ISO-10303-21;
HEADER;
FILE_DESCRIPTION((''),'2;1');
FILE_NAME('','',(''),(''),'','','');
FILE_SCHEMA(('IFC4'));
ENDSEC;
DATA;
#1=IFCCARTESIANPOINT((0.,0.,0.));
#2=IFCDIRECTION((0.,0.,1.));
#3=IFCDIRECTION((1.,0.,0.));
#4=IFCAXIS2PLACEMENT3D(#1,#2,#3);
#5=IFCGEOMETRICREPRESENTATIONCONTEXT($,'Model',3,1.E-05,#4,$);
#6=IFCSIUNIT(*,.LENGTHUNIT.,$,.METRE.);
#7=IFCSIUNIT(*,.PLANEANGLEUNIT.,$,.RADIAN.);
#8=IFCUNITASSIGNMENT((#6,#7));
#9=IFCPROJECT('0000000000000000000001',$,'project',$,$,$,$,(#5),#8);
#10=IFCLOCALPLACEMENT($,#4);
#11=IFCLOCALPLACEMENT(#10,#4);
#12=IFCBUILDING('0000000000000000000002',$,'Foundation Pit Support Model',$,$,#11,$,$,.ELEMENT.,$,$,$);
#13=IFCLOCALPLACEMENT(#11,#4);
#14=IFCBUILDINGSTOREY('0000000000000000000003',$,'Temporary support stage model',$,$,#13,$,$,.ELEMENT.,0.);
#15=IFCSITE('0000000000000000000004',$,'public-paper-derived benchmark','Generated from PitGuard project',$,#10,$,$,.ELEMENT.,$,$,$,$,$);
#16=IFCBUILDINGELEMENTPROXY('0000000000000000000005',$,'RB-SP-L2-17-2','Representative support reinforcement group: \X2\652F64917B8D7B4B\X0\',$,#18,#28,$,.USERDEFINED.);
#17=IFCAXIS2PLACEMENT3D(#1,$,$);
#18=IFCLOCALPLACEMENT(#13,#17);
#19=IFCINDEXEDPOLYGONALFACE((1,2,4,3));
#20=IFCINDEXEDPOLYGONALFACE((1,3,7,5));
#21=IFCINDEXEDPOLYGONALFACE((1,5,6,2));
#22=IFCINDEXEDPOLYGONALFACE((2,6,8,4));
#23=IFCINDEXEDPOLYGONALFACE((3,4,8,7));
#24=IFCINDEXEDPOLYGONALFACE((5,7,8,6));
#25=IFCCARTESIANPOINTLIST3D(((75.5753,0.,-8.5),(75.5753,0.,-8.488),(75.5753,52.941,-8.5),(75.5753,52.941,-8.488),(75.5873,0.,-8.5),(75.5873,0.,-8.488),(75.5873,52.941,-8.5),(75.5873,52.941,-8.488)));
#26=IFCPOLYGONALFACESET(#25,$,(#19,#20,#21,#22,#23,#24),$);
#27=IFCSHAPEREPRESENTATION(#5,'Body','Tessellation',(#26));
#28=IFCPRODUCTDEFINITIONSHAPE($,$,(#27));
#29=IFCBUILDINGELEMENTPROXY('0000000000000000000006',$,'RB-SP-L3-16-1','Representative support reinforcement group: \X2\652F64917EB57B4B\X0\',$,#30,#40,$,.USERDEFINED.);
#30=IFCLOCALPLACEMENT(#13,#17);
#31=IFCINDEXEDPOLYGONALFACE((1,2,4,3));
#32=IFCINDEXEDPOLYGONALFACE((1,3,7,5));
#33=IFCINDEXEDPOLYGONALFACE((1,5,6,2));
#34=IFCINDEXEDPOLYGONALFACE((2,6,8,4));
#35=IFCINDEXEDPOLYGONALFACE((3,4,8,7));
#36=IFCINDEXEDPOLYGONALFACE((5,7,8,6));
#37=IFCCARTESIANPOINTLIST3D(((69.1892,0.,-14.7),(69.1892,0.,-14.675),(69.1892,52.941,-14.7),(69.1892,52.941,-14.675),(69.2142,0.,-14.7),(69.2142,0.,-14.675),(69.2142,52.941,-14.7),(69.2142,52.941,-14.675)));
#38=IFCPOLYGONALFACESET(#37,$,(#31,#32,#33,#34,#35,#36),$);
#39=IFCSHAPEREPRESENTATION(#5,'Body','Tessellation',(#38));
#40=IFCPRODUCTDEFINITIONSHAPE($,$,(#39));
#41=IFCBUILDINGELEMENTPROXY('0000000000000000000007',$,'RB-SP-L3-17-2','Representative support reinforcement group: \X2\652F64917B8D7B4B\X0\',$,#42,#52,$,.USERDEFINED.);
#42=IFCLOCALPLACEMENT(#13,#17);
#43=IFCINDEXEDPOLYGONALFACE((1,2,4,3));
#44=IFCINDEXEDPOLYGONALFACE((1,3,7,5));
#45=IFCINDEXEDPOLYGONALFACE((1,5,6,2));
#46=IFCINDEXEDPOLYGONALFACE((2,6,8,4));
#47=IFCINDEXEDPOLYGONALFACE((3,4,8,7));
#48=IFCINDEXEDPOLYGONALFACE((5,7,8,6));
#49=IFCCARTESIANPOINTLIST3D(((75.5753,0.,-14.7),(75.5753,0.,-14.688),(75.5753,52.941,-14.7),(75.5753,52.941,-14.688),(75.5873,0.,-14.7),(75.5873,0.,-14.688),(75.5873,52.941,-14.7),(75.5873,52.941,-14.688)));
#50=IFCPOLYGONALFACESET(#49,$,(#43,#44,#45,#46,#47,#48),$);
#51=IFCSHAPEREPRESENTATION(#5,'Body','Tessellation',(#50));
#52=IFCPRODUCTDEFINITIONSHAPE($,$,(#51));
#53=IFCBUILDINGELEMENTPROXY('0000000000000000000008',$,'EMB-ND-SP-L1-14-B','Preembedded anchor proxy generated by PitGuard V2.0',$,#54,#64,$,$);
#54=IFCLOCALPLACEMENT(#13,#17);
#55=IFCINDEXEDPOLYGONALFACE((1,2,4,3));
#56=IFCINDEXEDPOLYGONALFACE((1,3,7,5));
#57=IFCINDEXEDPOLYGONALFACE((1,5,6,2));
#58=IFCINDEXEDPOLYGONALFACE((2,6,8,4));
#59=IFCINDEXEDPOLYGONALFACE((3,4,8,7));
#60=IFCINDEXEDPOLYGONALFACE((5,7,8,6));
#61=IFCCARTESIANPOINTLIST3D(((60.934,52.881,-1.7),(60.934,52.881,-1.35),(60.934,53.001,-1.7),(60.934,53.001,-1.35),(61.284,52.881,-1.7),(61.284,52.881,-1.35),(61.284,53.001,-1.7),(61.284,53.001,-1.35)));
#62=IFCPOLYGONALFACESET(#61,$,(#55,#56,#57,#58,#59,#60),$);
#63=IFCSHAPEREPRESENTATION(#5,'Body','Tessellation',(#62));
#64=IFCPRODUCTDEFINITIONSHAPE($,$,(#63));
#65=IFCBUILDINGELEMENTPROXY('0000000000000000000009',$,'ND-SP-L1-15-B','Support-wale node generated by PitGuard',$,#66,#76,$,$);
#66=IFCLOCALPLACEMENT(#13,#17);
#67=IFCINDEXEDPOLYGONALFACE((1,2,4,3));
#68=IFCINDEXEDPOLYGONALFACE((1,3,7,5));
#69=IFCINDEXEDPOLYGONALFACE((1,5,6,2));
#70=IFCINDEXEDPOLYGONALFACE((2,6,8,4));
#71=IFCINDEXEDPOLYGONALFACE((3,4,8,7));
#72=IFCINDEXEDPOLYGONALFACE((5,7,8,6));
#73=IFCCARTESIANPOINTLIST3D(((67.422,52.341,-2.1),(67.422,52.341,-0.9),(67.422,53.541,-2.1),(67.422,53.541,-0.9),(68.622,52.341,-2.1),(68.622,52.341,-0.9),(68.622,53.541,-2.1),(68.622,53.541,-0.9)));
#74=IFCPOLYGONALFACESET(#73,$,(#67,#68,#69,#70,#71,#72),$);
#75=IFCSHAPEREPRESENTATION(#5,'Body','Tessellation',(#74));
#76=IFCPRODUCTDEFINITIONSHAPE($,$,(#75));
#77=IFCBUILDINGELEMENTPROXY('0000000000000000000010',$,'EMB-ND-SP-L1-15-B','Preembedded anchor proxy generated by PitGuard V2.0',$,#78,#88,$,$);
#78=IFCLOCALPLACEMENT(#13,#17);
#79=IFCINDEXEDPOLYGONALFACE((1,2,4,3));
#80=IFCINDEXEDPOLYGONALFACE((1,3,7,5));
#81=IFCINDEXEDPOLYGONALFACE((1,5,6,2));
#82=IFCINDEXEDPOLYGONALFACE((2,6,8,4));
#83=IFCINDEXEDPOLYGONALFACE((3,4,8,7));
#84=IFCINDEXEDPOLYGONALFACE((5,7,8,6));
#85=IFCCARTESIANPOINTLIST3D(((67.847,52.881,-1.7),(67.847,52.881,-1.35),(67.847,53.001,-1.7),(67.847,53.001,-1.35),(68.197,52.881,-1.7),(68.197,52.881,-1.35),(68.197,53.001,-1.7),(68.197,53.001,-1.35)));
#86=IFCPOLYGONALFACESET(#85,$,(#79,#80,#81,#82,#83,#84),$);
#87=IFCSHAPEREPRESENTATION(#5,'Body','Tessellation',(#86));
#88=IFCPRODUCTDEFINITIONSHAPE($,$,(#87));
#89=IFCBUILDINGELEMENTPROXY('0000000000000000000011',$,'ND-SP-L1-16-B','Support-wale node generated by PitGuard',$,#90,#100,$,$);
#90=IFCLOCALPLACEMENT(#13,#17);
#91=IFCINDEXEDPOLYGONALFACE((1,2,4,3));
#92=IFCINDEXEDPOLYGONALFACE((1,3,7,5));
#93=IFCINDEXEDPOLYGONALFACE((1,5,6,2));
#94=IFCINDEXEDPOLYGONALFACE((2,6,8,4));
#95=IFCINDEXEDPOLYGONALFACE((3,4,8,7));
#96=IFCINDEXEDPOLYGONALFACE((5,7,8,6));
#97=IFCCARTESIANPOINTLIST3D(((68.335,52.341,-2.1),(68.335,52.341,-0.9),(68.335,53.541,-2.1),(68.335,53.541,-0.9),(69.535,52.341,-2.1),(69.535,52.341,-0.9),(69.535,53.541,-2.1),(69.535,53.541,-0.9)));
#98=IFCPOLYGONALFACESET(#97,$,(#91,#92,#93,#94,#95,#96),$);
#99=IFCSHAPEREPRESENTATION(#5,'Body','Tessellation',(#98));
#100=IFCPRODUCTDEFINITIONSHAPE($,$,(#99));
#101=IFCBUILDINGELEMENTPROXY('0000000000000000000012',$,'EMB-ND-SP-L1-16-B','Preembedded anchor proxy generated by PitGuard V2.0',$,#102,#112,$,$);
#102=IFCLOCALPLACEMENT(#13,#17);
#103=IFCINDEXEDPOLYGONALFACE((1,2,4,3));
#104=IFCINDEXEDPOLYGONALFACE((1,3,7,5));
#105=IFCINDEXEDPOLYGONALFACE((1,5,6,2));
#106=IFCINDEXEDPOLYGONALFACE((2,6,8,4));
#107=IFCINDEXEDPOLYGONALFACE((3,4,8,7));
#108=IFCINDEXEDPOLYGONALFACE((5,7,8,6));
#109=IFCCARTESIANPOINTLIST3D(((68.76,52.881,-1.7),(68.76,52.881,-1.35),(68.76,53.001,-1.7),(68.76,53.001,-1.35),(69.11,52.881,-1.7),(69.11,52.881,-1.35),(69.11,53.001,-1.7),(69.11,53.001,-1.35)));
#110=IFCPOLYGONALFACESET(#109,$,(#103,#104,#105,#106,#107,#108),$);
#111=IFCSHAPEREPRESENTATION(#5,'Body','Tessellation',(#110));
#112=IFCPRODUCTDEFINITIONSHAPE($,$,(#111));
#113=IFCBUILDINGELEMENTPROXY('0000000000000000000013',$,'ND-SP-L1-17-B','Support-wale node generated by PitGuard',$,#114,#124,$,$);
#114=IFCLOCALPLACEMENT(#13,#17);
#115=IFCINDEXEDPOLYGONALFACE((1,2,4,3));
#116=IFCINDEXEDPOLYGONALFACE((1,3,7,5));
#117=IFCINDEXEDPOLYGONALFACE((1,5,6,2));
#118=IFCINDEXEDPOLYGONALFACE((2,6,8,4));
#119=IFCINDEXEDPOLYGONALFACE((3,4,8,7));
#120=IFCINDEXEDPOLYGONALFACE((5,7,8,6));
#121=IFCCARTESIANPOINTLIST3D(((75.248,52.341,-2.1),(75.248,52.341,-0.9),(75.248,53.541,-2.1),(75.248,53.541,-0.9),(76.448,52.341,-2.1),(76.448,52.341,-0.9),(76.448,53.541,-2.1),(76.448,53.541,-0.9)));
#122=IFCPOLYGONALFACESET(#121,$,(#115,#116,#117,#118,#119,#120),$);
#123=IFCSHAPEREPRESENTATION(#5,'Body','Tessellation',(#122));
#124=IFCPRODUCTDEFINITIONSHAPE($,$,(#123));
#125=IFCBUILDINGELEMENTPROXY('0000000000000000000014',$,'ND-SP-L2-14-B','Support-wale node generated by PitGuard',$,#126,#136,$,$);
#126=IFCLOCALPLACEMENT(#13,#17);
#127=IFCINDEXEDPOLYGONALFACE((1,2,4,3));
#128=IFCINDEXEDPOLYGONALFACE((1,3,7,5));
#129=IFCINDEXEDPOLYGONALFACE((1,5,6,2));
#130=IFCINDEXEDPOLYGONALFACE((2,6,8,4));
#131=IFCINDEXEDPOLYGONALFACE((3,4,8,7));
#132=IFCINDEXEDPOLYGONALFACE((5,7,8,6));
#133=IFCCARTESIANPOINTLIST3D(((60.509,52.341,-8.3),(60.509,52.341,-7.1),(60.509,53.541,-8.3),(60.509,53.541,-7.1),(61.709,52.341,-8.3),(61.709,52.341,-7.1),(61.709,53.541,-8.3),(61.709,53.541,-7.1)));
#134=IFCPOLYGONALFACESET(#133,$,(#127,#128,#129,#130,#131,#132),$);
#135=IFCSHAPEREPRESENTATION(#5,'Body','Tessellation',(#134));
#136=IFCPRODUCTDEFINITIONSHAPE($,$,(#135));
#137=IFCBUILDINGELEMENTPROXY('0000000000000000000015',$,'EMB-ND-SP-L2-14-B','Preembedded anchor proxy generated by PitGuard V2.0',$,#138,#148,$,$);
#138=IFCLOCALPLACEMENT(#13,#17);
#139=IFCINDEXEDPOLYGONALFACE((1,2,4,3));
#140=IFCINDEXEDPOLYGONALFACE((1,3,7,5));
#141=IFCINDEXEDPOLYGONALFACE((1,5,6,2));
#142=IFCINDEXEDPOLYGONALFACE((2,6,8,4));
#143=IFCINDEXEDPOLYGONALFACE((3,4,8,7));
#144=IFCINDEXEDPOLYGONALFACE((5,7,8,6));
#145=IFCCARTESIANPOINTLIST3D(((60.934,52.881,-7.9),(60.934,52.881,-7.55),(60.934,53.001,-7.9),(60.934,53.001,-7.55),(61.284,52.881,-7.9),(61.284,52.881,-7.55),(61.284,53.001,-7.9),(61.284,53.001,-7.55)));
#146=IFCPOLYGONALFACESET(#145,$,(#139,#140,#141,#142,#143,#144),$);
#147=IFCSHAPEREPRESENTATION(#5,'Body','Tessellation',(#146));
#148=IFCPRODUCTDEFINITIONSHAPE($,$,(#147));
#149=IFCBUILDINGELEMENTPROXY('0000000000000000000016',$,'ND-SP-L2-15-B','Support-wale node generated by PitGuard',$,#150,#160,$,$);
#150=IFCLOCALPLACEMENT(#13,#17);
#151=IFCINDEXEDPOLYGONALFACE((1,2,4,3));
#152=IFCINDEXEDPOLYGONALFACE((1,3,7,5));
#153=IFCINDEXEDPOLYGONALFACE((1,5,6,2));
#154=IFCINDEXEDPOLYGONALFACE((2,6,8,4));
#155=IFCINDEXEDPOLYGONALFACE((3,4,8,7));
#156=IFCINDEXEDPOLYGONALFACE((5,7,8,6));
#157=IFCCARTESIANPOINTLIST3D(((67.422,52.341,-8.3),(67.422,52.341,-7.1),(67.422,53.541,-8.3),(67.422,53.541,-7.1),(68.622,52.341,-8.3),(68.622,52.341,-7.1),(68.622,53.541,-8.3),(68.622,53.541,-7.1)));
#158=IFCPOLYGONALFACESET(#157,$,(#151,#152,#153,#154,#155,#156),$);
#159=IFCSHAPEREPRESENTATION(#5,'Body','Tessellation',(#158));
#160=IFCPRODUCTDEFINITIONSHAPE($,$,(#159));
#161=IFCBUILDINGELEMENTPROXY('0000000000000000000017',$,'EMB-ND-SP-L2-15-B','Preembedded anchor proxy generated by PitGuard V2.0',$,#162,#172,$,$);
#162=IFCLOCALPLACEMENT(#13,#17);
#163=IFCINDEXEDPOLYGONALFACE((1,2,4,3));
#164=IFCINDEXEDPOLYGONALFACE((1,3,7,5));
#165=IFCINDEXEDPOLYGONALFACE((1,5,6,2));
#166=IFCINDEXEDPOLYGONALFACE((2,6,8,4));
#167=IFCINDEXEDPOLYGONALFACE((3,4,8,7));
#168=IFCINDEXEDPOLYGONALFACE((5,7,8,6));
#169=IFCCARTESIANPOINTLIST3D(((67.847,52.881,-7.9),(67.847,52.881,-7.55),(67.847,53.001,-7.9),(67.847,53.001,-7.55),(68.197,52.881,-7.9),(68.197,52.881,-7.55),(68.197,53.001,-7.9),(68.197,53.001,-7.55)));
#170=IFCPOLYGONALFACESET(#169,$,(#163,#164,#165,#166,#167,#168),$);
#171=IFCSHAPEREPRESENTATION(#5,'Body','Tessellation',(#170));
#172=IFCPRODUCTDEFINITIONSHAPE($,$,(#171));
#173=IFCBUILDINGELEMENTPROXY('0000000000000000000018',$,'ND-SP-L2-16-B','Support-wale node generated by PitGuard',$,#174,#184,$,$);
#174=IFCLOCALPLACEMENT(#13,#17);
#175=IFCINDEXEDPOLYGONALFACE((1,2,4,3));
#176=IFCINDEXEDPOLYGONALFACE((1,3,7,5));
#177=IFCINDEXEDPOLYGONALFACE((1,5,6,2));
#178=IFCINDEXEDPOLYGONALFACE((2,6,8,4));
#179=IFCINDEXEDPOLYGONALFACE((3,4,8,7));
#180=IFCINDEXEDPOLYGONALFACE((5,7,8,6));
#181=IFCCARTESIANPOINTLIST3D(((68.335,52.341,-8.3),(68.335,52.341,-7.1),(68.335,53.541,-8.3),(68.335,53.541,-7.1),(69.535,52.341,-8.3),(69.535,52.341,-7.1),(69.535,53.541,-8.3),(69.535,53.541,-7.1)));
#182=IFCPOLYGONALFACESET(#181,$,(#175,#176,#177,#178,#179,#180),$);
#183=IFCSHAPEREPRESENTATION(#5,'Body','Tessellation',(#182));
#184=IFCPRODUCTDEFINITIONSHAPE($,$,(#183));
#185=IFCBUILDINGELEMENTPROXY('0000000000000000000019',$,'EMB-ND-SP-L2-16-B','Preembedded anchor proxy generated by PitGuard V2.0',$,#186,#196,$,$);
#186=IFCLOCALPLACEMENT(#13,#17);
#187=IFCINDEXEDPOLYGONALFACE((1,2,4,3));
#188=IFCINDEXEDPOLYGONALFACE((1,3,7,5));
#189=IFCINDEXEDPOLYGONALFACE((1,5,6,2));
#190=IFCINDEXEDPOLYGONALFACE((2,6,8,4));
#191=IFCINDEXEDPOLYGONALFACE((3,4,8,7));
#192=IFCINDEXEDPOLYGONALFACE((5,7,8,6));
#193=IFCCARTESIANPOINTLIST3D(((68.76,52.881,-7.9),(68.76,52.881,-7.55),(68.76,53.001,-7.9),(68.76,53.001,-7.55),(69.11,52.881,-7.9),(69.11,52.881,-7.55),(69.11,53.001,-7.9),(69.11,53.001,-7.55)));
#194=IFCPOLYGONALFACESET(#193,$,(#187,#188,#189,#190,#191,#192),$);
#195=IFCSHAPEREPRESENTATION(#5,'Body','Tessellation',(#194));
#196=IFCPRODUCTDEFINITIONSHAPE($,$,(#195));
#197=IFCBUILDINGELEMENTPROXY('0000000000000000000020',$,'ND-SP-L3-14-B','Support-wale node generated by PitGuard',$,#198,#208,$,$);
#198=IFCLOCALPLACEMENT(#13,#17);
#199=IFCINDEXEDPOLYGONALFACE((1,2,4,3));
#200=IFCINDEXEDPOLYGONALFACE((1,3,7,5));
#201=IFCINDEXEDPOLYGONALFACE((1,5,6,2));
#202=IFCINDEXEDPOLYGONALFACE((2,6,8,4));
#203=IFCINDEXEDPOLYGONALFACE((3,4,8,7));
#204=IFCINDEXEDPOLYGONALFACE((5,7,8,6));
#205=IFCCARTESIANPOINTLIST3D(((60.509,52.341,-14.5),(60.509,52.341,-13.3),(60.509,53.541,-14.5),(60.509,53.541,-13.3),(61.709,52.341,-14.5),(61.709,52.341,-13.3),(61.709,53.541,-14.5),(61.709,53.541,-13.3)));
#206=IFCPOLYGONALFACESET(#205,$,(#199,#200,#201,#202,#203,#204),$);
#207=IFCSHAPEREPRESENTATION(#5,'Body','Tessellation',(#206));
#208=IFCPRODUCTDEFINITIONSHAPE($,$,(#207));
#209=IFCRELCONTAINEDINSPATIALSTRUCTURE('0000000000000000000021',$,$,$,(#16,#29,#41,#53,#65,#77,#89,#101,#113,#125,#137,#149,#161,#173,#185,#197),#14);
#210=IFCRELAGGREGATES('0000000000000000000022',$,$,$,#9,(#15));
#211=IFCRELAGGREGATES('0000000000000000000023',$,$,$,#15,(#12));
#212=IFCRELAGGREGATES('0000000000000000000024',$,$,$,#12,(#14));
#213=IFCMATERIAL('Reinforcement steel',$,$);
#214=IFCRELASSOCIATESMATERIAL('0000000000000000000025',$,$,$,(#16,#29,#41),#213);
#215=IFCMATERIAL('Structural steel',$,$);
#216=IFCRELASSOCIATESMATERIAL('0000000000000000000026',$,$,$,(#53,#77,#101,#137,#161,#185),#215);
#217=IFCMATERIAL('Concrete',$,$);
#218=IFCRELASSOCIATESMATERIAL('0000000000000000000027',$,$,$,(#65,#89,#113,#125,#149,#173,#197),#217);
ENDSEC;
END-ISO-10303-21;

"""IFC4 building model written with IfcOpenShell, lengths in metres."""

from ifc_helpers import new_model, si_unit, frame, origin_with_axes, origin_2d, place, context, project, spatial, rectangle, extrude, material, element, save


model = new_model("IFC4")

# Units and contexts
model_context = context("Model", 3, precision=1e-05, world=origin_with_axes())
ifc_project = project(units=[si_unit("LENGTHUNIT", "METRE"), si_unit("PLANEANGLEUNIT", "RADIAN")], contexts=[model_context])

# Site, building, storey
site_placement = place(None, origin_with_axes())
site = spatial("IfcSite", under=ifc_project, at=site_placement, Name="public-paper-derived benchmark", Description="Generated from PitGuard project", CompositionType="ELEMENT")
building_placement = place(site_placement, origin_with_axes())
building = spatial("IfcBuilding", under=site, at=building_placement, Name="Foundation Pit Support Model", CompositionType="ELEMENT")
storey_placement = place(building_placement, origin_with_axes())
storey = spatial("IfcBuildingStorey", under=building, at=storey_placement, Name="Temporary support stage model", CompositionType="ELEMENT", Elevation=0.0)

# Shared definitions
ifc_material_1 = material(Name="Structural steel")

# Shared definitions
ifc_material_2 = material(Name="Concrete")

# Building element proxies
ifc_material_3 = material(Name="Reinforcement steel")
proxy_1_placement = place(storey_placement, frame((75.5813, 26.4705, -8.5), z_axis=(0.0, 0.0, 1.0), x_axis=(0.0, 1.0, 0.0)))
element("IfcBuildingElementProxy", 1, at=proxy_1_placement, inside=storey, material=ifc_material_3, Name="RB-SP-L2-17-2", Description="Representative support reinforcement group: 支撑箍筋", PredefinedType="USERDEFINED", context=model_context, shape_type="SweptSolid", body=[
    extrude(rectangle(XDim=52.941, YDim=0.012, at=origin_2d()), origin_with_axes(), (0.0, 0.0, 1.0), 0.012),
])
proxy_2_placement = place(storey_placement, frame((69.2017, 26.4705, -14.7), z_axis=(0.0, 0.0, 1.0), x_axis=(0.0, 1.0, 0.0)))
element("IfcBuildingElementProxy", 2, at=proxy_2_placement, inside=storey, material=ifc_material_3, Name="RB-SP-L3-16-1", Description="Representative support reinforcement group: 支撑纵筋", PredefinedType="USERDEFINED", context=model_context, shape_type="SweptSolid", body=[
    extrude(rectangle(XDim=52.941, YDim=0.025, at=origin_2d()), origin_with_axes(), (0.0, 0.0, 1.0), 0.025),
])
proxy_3_placement = place(storey_placement, frame((75.5813, 26.4705, -14.7), z_axis=(0.0, 0.0, 1.0), x_axis=(0.0, 1.0, 0.0)))
element("IfcBuildingElementProxy", 3, at=proxy_3_placement, inside=storey, material=ifc_material_3, Name="RB-SP-L3-17-2", Description="Representative support reinforcement group: 支撑箍筋", PredefinedType="USERDEFINED", context=model_context, shape_type="SweptSolid", body=[
    extrude(rectangle(XDim=52.941, YDim=0.012, at=origin_2d()), origin_with_axes(), (0.0, 0.0, 1.0), 0.012),
])
proxy_4_placement = place(storey_placement, frame((61.109, 52.941, -1.7), z_axis=(0.0, 0.0, 1.0), x_axis=(1.0, 0.0, 0.0)))
element("IfcBuildingElementProxy", 4, at=proxy_4_placement, inside=storey, material=ifc_material_1, Name="EMB-ND-SP-L1-14-B", Description="Preembedded anchor proxy generated by PitGuard V2.0", context=model_context, shape_type="SweptSolid", body=[
    extrude(rectangle(XDim=0.35, YDim=0.12, at=origin_2d()), origin_with_axes(), (0.0, 0.0, 1.0), 0.35),
])
proxy_5_placement = place(storey_placement, frame((68.022, 52.941, -2.1), z_axis=(0.0, 0.0, 1.0), x_axis=(1.0, 0.0, 0.0)))
element("IfcBuildingElementProxy", 5, at=proxy_5_placement, inside=storey, material=ifc_material_2, Name="ND-SP-L1-15-B", Description="Support-wale node generated by PitGuard", context=model_context, shape_type="SweptSolid", body=[
    extrude(rectangle(XDim=1.2, YDim=1.2, at=origin_2d()), origin_with_axes(), (0.0, 0.0, 1.0), 1.2),
])
proxy_6_placement = place(storey_placement, frame((68.022, 52.941, -1.7), z_axis=(0.0, 0.0, 1.0), x_axis=(1.0, 0.0, 0.0)))
element("IfcBuildingElementProxy", 6, at=proxy_6_placement, inside=storey, material=ifc_material_1, Name="EMB-ND-SP-L1-15-B", Description="Preembedded anchor proxy generated by PitGuard V2.0", context=model_context, shape_type="SweptSolid", body=[
    extrude(rectangle(XDim=0.35, YDim=0.12, at=origin_2d()), origin_with_axes(), (0.0, 0.0, 1.0), 0.35),
])
proxy_7_placement = place(storey_placement, frame((68.935, 52.941, -2.1), z_axis=(0.0, 0.0, 1.0), x_axis=(1.0, 0.0, 0.0)))
element("IfcBuildingElementProxy", 7, at=proxy_7_placement, inside=storey, material=ifc_material_2, Name="ND-SP-L1-16-B", Description="Support-wale node generated by PitGuard", context=model_context, shape_type="SweptSolid", body=[
    extrude(rectangle(XDim=1.2, YDim=1.2, at=origin_2d()), origin_with_axes(), (0.0, 0.0, 1.0), 1.2),
])
proxy_8_placement = place(storey_placement, frame((68.935, 52.941, -1.7), z_axis=(0.0, 0.0, 1.0), x_axis=(1.0, 0.0, 0.0)))
element("IfcBuildingElementProxy", 8, at=proxy_8_placement, inside=storey, material=ifc_material_1, Name="EMB-ND-SP-L1-16-B", Description="Preembedded anchor proxy generated by PitGuard V2.0", context=model_context, shape_type="SweptSolid", body=[
    extrude(rectangle(XDim=0.35, YDim=0.12, at=origin_2d()), origin_with_axes(), (0.0, 0.0, 1.0), 0.35),
])
for number, where, z_axis, x_axis, name in (
    (9, (75.848, 52.941, -2.1), (0.0, 0.0, 1.0), (1.0, 0.0, 0.0), "ND-SP-L1-17-B"),
    (10, (61.109, 52.941, -8.3), (0.0, 0.0, 1.0), (1.0, 0.0, 0.0), "ND-SP-L2-14-B"),
):
    element("IfcBuildingElementProxy", number, at=place(storey_placement, frame(where, z_axis=z_axis, x_axis=x_axis)), inside=storey, material=ifc_material_2, Name=name, Description="Support-wale node generated by PitGuard", context=model_context, shape_type="SweptSolid", body=[
        extrude(rectangle(XDim=1.2, YDim=1.2, at=origin_2d()), origin_with_axes(), (0.0, 0.0, 1.0), 1.2),
    ])
proxy_9_placement = place(storey_placement, frame((61.109, 52.941, -7.9), z_axis=(0.0, 0.0, 1.0), x_axis=(1.0, 0.0, 0.0)))
element("IfcBuildingElementProxy", 11, at=proxy_9_placement, inside=storey, material=ifc_material_1, Name="EMB-ND-SP-L2-14-B", Description="Preembedded anchor proxy generated by PitGuard V2.0", context=model_context, shape_type="SweptSolid", body=[
    extrude(rectangle(XDim=0.35, YDim=0.12, at=origin_2d()), origin_with_axes(), (0.0, 0.0, 1.0), 0.35),
])
proxy_10_placement = place(storey_placement, frame((68.022, 52.941, -8.3), z_axis=(0.0, 0.0, 1.0), x_axis=(1.0, 0.0, 0.0)))
element("IfcBuildingElementProxy", 12, at=proxy_10_placement, inside=storey, material=ifc_material_2, Name="ND-SP-L2-15-B", Description="Support-wale node generated by PitGuard", context=model_context, shape_type="SweptSolid", body=[
    extrude(rectangle(XDim=1.2, YDim=1.2, at=origin_2d()), origin_with_axes(), (0.0, 0.0, 1.0), 1.2),
])
proxy_11_placement = place(storey_placement, frame((68.022, 52.941, -7.9), z_axis=(0.0, 0.0, 1.0), x_axis=(1.0, 0.0, 0.0)))
element("IfcBuildingElementProxy", 13, at=proxy_11_placement, inside=storey, material=ifc_material_1, Name="EMB-ND-SP-L2-15-B", Description="Preembedded anchor proxy generated by PitGuard V2.0", context=model_context, shape_type="SweptSolid", body=[
    extrude(rectangle(XDim=0.35, YDim=0.12, at=origin_2d()), origin_with_axes(), (0.0, 0.0, 1.0), 0.35),
])
proxy_12_placement = place(storey_placement, frame((68.935, 52.941, -8.3), z_axis=(0.0, 0.0, 1.0), x_axis=(1.0, 0.0, 0.0)))
element("IfcBuildingElementProxy", 14, at=proxy_12_placement, inside=storey, material=ifc_material_2, Name="ND-SP-L2-16-B", Description="Support-wale node generated by PitGuard", context=model_context, shape_type="SweptSolid", body=[
    extrude(rectangle(XDim=1.2, YDim=1.2, at=origin_2d()), origin_with_axes(), (0.0, 0.0, 1.0), 1.2),
])
proxy_13_placement = place(storey_placement, frame((68.935, 52.941, -7.9), z_axis=(0.0, 0.0, 1.0), x_axis=(1.0, 0.0, 0.0)))
element("IfcBuildingElementProxy", 15, at=proxy_13_placement, inside=storey, material=ifc_material_1, Name="EMB-ND-SP-L2-16-B", Description="Preembedded anchor proxy generated by PitGuard V2.0", context=model_context, shape_type="SweptSolid", body=[
    extrude(rectangle(XDim=0.35, YDim=0.12, at=origin_2d()), origin_with_axes(), (0.0, 0.0, 1.0), 0.35),
])
proxy_14_placement = place(storey_placement, frame((61.109, 52.941, -14.5), z_axis=(0.0, 0.0, 1.0), x_axis=(1.0, 0.0, 0.0)))
element("IfcBuildingElementProxy", 16, at=proxy_14_placement, inside=storey, material=ifc_material_2, Name="ND-SP-L3-14-B", Description="Support-wale node generated by PitGuard", context=model_context, shape_type="SweptSolid", body=[
    extrude(rectangle(XDim=1.2, YDim=1.2, at=origin_2d()), origin_with_axes(), (0.0, 0.0, 1.0), 1.2),
])

save(model, "model.ifc")
